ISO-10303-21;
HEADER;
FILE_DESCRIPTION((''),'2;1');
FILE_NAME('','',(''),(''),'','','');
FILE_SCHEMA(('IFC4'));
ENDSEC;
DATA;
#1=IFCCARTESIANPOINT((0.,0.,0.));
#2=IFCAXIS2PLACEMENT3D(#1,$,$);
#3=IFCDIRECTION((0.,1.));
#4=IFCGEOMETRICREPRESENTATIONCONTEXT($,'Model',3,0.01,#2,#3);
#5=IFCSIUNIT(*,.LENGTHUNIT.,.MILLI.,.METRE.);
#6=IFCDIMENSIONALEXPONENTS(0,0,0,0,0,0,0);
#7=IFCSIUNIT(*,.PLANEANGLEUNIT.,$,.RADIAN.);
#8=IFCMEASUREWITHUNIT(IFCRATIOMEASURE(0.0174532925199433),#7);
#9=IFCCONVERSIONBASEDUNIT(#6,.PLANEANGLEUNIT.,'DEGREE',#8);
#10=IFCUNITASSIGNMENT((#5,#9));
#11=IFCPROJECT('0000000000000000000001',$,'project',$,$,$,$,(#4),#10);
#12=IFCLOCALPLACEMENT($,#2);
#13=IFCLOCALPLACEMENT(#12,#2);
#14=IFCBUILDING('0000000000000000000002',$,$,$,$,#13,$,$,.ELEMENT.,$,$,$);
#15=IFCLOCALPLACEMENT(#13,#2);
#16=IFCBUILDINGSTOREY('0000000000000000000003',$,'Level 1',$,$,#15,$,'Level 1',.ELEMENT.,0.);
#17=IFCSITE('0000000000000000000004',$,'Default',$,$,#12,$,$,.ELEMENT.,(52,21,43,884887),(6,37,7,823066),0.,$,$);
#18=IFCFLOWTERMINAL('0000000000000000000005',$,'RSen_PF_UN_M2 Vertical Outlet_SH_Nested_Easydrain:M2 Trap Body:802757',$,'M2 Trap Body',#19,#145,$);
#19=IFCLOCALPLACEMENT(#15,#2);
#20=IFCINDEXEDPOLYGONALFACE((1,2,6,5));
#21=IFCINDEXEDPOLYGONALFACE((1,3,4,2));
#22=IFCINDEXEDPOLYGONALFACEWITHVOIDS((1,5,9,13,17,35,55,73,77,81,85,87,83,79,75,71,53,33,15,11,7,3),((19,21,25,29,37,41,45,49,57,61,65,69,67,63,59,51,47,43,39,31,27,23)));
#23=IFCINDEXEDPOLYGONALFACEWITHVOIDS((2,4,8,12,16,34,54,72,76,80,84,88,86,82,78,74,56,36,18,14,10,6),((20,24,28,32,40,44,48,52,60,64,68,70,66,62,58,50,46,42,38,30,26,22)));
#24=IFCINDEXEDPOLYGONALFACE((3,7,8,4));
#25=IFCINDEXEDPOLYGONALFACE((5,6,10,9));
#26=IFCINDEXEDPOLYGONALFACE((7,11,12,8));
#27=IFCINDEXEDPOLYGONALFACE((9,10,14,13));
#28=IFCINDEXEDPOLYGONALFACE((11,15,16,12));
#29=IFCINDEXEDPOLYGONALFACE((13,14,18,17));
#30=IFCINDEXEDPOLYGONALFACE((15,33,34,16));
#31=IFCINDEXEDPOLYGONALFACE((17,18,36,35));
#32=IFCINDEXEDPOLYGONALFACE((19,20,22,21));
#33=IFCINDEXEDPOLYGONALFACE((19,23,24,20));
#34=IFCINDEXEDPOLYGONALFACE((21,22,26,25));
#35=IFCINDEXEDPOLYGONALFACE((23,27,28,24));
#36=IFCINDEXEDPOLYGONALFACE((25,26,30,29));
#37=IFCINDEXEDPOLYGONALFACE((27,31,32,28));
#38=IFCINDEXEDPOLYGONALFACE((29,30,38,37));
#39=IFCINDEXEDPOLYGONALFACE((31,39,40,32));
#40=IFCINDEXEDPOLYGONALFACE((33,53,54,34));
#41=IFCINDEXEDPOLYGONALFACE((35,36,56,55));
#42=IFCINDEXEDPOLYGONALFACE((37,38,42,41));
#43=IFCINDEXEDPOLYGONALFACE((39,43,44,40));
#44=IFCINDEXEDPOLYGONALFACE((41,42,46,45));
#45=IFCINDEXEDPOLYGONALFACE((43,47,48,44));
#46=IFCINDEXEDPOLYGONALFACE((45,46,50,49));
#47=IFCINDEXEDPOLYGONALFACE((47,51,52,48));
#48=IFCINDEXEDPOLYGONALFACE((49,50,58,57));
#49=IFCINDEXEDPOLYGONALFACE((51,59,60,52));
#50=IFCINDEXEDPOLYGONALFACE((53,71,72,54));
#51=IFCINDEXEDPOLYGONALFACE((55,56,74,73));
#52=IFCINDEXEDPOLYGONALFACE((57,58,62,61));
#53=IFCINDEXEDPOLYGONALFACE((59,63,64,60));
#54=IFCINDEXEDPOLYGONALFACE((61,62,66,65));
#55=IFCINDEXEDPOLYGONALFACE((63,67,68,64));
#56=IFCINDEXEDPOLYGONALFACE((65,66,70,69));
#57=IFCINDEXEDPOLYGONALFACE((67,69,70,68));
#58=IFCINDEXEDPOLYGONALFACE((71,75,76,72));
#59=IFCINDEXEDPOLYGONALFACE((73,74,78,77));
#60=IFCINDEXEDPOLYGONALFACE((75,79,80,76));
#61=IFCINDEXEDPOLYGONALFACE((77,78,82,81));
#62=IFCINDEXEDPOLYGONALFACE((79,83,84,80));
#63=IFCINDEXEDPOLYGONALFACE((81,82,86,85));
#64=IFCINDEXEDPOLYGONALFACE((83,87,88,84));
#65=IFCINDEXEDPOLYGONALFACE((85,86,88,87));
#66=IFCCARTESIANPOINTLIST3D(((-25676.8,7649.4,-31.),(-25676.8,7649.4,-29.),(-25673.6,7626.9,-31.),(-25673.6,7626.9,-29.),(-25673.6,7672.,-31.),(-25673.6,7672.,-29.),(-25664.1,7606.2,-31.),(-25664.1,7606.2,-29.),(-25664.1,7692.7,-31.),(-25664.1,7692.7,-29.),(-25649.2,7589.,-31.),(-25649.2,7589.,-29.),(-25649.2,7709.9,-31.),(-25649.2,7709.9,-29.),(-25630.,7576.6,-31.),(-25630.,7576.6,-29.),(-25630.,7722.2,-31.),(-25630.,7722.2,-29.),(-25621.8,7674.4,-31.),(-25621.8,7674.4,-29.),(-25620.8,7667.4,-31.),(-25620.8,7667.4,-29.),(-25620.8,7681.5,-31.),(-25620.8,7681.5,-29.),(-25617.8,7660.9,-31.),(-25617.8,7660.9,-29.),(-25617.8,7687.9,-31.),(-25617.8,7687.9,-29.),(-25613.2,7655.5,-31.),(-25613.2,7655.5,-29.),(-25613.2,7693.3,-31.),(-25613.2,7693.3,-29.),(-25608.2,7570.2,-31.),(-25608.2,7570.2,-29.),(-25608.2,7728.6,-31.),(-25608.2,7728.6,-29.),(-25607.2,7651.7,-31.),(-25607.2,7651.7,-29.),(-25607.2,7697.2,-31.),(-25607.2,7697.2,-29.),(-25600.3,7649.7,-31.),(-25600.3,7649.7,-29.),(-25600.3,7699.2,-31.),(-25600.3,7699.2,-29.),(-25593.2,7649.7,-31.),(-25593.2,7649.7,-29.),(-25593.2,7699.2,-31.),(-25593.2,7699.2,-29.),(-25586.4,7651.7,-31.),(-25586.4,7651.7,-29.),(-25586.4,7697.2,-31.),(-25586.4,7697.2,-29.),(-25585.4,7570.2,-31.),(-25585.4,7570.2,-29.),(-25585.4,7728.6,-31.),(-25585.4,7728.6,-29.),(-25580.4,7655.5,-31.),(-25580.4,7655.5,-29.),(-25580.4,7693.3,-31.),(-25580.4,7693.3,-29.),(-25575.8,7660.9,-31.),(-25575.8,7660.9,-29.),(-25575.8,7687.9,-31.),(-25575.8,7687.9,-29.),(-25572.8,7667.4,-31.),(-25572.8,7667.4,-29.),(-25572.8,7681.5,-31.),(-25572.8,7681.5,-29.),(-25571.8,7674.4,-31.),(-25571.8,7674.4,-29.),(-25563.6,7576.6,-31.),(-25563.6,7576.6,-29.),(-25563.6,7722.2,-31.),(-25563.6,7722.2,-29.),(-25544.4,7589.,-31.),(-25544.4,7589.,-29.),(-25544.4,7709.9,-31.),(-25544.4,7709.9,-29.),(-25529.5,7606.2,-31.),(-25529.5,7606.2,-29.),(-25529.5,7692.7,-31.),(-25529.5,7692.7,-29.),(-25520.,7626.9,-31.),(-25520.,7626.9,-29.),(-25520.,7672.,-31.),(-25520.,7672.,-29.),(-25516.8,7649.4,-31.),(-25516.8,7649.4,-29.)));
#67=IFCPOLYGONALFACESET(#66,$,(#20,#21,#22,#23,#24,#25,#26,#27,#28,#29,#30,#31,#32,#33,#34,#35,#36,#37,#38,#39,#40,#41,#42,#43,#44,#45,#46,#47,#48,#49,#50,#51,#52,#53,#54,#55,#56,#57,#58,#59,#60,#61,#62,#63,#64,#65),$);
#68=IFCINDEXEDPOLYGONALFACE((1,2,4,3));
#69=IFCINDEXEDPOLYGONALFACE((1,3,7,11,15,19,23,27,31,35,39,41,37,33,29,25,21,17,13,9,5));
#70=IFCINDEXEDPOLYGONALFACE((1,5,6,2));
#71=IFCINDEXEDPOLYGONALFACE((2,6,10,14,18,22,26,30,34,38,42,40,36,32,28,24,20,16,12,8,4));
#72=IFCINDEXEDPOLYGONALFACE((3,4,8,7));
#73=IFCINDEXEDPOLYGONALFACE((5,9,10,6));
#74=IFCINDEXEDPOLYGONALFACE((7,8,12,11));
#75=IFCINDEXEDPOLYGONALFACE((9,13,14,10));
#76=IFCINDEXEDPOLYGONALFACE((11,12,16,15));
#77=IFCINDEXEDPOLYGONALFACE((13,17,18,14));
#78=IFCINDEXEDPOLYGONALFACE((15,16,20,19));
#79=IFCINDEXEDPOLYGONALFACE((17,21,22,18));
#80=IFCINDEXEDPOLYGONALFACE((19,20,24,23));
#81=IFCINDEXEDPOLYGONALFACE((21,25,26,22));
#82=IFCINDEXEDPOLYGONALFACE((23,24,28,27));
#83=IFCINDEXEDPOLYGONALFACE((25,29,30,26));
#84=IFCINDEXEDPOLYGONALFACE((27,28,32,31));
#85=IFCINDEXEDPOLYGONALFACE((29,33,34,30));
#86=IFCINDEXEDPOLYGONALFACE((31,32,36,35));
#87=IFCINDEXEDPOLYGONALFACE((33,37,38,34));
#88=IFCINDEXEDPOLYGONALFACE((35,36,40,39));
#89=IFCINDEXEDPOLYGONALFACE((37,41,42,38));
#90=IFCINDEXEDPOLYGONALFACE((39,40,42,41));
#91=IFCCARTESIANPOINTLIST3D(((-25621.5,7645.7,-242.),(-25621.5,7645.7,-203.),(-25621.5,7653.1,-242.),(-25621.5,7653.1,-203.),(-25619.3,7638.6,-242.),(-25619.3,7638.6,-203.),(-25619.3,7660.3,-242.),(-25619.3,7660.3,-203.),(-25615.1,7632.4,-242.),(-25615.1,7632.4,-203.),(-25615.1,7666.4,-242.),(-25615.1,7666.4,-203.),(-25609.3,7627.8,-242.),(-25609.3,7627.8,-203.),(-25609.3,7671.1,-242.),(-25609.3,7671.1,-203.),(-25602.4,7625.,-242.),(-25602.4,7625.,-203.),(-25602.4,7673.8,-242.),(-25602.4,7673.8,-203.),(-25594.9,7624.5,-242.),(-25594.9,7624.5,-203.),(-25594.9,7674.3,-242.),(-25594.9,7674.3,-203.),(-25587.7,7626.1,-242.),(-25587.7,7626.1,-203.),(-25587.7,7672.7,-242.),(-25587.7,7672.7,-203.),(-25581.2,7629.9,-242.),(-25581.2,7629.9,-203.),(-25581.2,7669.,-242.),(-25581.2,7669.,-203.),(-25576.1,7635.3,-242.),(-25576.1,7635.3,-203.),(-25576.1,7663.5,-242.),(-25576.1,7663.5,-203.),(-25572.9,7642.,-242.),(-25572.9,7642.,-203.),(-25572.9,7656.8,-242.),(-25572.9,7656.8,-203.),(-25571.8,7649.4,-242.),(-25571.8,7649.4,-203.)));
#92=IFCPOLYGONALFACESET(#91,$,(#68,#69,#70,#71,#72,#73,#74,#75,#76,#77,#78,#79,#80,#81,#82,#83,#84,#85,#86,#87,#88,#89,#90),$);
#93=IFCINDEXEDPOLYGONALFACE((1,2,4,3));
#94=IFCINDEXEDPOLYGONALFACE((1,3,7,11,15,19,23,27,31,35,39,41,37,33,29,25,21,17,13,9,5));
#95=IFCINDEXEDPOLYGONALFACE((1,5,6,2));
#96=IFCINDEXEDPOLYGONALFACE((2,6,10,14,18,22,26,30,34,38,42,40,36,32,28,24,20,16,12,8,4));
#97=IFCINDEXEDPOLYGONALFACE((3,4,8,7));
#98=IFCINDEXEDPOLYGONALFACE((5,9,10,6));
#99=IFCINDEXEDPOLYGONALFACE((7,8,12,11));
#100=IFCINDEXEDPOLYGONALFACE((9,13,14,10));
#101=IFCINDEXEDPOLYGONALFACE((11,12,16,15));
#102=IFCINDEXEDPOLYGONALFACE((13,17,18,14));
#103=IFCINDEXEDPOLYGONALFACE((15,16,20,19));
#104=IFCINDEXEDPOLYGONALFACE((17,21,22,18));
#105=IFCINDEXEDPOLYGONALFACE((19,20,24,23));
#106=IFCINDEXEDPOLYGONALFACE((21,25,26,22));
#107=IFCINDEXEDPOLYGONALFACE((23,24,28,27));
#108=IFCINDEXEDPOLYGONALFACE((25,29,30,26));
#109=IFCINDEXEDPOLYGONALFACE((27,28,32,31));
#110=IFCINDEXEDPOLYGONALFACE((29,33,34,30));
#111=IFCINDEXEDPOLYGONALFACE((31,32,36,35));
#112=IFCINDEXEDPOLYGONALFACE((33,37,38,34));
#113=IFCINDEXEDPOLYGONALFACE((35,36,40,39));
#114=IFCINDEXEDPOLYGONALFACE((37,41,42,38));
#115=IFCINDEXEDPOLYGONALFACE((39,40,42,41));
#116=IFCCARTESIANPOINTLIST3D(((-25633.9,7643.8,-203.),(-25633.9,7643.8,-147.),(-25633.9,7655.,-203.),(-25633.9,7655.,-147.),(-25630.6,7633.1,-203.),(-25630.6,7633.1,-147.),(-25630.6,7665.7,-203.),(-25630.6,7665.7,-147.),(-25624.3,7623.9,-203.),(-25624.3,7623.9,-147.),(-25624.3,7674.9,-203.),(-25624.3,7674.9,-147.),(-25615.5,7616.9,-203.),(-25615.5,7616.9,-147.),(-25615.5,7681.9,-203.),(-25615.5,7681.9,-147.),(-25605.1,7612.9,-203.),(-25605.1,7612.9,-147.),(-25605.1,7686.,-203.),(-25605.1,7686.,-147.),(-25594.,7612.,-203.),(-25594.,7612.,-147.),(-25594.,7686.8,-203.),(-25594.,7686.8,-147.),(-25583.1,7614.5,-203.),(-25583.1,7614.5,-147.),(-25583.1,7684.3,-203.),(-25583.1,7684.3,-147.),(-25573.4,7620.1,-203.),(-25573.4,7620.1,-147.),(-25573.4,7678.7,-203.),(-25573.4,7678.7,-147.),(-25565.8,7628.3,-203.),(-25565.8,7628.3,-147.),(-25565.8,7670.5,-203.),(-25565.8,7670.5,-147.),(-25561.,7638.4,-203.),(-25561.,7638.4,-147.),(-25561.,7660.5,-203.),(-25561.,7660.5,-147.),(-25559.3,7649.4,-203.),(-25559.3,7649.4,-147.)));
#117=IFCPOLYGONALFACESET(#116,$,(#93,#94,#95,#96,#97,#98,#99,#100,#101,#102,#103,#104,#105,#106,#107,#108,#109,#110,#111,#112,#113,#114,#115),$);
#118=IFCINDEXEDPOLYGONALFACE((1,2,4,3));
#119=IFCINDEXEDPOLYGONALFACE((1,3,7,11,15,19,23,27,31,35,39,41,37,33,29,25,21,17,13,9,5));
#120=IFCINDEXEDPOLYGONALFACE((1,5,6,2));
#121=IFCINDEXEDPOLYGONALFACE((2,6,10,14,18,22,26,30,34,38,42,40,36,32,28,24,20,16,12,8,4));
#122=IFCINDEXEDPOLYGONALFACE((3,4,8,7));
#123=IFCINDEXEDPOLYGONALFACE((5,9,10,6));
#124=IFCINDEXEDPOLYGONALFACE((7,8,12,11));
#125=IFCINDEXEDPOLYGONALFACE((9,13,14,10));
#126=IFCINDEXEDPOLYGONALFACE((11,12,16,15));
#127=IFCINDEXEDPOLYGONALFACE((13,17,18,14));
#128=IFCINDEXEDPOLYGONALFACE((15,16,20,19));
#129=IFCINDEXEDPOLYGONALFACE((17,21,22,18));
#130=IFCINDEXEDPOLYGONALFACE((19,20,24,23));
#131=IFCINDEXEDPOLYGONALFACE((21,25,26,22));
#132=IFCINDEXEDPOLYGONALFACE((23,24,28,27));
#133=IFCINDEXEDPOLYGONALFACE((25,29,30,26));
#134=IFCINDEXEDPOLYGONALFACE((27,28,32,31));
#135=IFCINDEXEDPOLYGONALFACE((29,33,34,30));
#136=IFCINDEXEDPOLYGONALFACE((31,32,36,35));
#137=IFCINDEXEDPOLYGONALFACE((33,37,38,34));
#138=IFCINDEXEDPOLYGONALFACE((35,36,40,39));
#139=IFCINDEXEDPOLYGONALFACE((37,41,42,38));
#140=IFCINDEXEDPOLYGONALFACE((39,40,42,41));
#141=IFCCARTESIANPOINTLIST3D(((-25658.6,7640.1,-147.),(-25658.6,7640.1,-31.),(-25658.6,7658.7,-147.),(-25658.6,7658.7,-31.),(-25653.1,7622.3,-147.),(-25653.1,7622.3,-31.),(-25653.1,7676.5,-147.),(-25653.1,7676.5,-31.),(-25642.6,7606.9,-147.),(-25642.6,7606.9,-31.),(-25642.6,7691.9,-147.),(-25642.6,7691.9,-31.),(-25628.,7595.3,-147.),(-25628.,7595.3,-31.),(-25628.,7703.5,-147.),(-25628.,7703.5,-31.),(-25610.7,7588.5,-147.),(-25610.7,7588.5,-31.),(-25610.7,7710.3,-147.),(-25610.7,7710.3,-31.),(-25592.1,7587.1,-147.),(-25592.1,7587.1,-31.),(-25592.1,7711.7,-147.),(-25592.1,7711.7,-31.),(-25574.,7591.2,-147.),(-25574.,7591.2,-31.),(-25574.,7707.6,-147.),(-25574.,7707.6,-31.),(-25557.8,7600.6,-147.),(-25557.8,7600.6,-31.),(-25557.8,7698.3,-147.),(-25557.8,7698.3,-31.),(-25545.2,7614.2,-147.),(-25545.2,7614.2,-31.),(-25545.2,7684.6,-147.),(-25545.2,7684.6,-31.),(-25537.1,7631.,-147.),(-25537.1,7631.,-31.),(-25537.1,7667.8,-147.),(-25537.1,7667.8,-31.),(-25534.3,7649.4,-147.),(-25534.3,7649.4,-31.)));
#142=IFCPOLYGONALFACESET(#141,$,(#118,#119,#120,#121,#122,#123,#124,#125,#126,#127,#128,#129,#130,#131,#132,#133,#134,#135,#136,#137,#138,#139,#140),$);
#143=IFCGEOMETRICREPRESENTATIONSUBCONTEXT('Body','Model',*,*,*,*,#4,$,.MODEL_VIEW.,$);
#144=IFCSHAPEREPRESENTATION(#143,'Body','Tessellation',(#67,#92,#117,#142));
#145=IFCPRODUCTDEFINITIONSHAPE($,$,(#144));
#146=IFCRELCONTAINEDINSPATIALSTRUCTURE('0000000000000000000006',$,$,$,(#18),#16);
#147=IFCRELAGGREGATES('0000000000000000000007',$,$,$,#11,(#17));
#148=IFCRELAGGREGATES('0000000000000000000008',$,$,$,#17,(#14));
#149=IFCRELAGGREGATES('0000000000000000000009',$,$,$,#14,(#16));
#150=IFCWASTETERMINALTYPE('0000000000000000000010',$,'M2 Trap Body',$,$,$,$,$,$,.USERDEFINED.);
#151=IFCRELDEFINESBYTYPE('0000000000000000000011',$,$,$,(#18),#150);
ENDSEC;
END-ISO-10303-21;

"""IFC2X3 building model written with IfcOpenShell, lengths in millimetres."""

from ifc_helpers import new_model, entity, si_unit, converted_unit, direction, frame, frame_2d, origin, origin_2d_with_axis, place, context, subcontext, project, spatial, circle_curve, parameter, trimmed, segment, composite_curve, circle, outline, extrude, source, transform, mapped, type_object, type_shapes, element, save


model = new_model("IFC2X3")

# Units and contexts
model_context = context("Model", 3, precision=0.01, world=origin(), true_north=direction((0.0, 1.0)))
body_context = subcontext(model_context, "Body", "Model", "MODEL_VIEW")
ifc_project = project(units=[si_unit("LENGTHUNIT", "METRE", prefix="MILLI"), converted_unit("PLANEANGLEUNIT", "DEGREE", entity("IfcRatioMeasure", 0.0174532925199433), si_unit("PLANEANGLEUNIT", "RADIAN"), dimensions=[0, 0, 0, 0, 0, 0, 0])], contexts=[model_context])

# Site, building, storey
site_placement = place(None, origin())
site = spatial("IfcSite", under=ifc_project, at=site_placement, Name="Default", CompositionType="ELEMENT", RefLatitude=(52, 21, 43, 884887), RefLongitude=(6, 37, 7, 823066), RefElevation=0.0)
building_placement = place(site_placement, origin())
building = spatial("IfcBuilding", under=site, at=building_placement, CompositionType="ELEMENT")
storey_placement = place(building_placement, origin())
storey = spatial("IfcBuildingStorey", under=building, at=storey_placement, Name="Level 1", LongName="Level 1", CompositionType="ELEMENT", Elevation=0.0)

# Flow terminal
waste_terminal_type_1 = type_object("IfcWasteTerminalType", Name="M2 Trap Body", PredefinedType="USERDEFINED")
shared_shape_1 = source(origin(), body_context, "Body", "SweptSolid", [
    extrude(outline(composite_curve([segment(trimmed(circle_curve(origin_2d_with_axis(), 80.0), [parameter(0.0)], [parameter(180.0)], True, "PARAMETER"), True, "CONTINUOUS"), segment(trimmed(circle_curve(origin_2d_with_axis(), 80.0), [parameter(180.0)], [parameter(360.0)], True, "PARAMETER"), True, "CONTINUOUS")], self_intersect=False), holes=[composite_curve([segment(trimmed(circle_curve(frame_2d((0.0, 25.0), x_axis=(1.0, 0.0)), 25.0), [parameter(180.0)], [parameter(360.0)], True, "PARAMETER"), False, "CONTINUOUS"), segment(trimmed(circle_curve(frame_2d((0.0, 25.0), x_axis=(1.0, 0.0)), 25.0), [parameter(0.0)], [parameter(180.0)], True, "PARAMETER"), False, "CONTINUOUS")], self_intersect=False)]), frame((0.0, -25.0, -2.0)), (0.0, 0.0, 1.0), 2.0),
    extrude(circle(Radius=25.0, at=frame_2d((0.0, 0.0), x_axis=(1.0, 0.0))), frame((0.0, -25.0, -213.0)), (0.0, 0.0, 1.0), 39.0),
    extrude(circle(Radius=37.5, at=frame_2d((0.0, 0.0), x_axis=(1.0, 0.0))), frame((0.0, -25.0, -174.0)), (0.0, 0.0, 1.0), 56.0),
    extrude(circle(Radius=62.5, at=frame_2d((0.0, 0.0), x_axis=(1.0, 0.0))), frame((0.0, -25.0, -118.0)), (0.0, 0.0, 1.0), 116.0),
])
type_shapes(waste_terminal_type_1, [shared_shape_1])
for number, where, name in (
    (1, (-25596.8, 7674.4, -29.0), "RSen_PF_UN_M2 Vertical Outlet_SH_Nested_Easydrain:M2 Trap Body:802757"),
):
    element("IfcFlowTerminal", number, at=place(storey_placement, frame(where)), inside=storey, type_object=waste_terminal_type_1, Name=name, ObjectType="M2 Trap Body", context=body_context, shape_type="MappedRepresentation", body=[
        mapped(shared_shape_1, transform((0.0, 0.0, 0.0), scale=1.0)),
    ])

save(model, "model.ifc")
